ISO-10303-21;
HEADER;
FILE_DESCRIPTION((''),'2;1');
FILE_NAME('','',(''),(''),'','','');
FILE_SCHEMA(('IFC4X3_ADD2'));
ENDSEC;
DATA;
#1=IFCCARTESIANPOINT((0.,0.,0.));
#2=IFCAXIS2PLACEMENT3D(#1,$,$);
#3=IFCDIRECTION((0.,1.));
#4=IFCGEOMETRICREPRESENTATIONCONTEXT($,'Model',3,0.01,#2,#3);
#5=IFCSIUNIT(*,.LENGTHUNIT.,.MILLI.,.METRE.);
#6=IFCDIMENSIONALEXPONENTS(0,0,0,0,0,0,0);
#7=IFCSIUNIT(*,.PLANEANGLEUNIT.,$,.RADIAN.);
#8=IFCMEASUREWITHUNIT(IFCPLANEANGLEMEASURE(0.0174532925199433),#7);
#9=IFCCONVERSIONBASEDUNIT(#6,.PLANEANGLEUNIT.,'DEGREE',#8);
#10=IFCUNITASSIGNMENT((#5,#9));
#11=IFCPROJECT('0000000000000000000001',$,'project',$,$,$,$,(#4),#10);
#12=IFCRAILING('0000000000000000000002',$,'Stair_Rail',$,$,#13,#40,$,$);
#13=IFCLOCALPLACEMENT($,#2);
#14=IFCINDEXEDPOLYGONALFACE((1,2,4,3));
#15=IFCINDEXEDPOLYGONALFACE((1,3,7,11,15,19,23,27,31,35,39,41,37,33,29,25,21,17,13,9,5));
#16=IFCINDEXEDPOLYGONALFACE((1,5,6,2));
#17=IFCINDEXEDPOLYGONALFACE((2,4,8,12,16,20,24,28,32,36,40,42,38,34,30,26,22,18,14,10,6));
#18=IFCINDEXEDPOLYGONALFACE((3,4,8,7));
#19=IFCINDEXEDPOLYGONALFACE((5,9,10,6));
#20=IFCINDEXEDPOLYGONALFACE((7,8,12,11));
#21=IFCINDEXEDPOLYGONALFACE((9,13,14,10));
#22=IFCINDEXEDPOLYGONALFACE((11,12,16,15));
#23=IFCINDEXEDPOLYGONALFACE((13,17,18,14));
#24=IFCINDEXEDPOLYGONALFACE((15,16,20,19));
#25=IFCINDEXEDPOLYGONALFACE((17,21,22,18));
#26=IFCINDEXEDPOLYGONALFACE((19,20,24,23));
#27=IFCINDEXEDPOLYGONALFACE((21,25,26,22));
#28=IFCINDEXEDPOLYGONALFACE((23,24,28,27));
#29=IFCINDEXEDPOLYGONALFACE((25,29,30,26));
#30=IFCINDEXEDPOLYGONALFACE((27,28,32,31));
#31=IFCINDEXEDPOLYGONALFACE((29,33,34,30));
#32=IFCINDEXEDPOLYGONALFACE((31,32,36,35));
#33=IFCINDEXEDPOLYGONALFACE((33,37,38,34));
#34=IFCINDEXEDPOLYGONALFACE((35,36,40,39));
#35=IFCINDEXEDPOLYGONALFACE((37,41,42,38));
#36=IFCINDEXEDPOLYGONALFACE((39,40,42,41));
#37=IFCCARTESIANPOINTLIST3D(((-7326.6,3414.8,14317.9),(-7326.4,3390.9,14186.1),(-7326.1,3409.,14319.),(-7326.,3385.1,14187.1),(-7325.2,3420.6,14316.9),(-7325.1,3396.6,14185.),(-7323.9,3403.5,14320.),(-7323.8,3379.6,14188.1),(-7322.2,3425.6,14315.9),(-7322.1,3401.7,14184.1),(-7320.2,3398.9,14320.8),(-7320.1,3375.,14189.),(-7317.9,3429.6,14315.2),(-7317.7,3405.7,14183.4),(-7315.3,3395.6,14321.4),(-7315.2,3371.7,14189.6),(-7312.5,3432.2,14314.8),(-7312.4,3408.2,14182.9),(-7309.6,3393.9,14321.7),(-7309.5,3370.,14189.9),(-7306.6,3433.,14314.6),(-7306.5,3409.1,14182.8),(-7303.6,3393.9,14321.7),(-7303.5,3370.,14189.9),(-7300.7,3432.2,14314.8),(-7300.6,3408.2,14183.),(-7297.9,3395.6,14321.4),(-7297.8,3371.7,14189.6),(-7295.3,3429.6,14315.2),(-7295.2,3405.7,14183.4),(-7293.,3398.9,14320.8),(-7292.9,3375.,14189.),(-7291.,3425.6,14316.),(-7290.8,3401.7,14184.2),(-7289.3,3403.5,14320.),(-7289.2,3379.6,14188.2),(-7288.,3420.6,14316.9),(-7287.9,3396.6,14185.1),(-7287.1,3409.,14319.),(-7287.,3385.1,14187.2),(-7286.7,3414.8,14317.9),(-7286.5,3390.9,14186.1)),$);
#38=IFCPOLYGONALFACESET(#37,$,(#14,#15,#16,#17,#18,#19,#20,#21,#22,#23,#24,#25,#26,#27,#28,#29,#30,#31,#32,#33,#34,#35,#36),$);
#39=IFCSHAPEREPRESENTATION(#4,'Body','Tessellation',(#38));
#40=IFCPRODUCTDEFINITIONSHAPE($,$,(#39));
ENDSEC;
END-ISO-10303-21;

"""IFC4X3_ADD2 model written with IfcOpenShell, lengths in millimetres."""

from ifc_helpers import new_model, entity, si_unit, converted_unit, direction, origin, context, project, element, save


model = new_model("IFC4X3_ADD2")

# Units and contexts
model_context = context("Model", 3, precision=0.01, world=origin(), true_north=direction((0.0, 1.0)))
ifc_project = project(units=[si_unit("LENGTHUNIT", "METRE", prefix="MILLI"), converted_unit("PLANEANGLEUNIT", "DEGREE", entity("IfcPlaneAngleMeasure", 0.0174532925199433), si_unit("PLANEANGLEUNIT", "RADIAN"), dimensions=[0, 0, 0, 0, 0, 0, 0])], contexts=[model_context])

# Railing
element("IfcRailing", 1, Name="Stair_Rail", context=model_context, shape_type="SweptSolid", body=[
    entity("IfcSweptDiskSolid", entity("IfcPolyline", [entity("IfcCartesianPoint", [-7306.5, 3389.4, 14186.4]), entity("IfcCartesianPoint", [-7306.6, 3413.4, 14318.2])]), 20.0),
])

save(model, "model.ifc")
